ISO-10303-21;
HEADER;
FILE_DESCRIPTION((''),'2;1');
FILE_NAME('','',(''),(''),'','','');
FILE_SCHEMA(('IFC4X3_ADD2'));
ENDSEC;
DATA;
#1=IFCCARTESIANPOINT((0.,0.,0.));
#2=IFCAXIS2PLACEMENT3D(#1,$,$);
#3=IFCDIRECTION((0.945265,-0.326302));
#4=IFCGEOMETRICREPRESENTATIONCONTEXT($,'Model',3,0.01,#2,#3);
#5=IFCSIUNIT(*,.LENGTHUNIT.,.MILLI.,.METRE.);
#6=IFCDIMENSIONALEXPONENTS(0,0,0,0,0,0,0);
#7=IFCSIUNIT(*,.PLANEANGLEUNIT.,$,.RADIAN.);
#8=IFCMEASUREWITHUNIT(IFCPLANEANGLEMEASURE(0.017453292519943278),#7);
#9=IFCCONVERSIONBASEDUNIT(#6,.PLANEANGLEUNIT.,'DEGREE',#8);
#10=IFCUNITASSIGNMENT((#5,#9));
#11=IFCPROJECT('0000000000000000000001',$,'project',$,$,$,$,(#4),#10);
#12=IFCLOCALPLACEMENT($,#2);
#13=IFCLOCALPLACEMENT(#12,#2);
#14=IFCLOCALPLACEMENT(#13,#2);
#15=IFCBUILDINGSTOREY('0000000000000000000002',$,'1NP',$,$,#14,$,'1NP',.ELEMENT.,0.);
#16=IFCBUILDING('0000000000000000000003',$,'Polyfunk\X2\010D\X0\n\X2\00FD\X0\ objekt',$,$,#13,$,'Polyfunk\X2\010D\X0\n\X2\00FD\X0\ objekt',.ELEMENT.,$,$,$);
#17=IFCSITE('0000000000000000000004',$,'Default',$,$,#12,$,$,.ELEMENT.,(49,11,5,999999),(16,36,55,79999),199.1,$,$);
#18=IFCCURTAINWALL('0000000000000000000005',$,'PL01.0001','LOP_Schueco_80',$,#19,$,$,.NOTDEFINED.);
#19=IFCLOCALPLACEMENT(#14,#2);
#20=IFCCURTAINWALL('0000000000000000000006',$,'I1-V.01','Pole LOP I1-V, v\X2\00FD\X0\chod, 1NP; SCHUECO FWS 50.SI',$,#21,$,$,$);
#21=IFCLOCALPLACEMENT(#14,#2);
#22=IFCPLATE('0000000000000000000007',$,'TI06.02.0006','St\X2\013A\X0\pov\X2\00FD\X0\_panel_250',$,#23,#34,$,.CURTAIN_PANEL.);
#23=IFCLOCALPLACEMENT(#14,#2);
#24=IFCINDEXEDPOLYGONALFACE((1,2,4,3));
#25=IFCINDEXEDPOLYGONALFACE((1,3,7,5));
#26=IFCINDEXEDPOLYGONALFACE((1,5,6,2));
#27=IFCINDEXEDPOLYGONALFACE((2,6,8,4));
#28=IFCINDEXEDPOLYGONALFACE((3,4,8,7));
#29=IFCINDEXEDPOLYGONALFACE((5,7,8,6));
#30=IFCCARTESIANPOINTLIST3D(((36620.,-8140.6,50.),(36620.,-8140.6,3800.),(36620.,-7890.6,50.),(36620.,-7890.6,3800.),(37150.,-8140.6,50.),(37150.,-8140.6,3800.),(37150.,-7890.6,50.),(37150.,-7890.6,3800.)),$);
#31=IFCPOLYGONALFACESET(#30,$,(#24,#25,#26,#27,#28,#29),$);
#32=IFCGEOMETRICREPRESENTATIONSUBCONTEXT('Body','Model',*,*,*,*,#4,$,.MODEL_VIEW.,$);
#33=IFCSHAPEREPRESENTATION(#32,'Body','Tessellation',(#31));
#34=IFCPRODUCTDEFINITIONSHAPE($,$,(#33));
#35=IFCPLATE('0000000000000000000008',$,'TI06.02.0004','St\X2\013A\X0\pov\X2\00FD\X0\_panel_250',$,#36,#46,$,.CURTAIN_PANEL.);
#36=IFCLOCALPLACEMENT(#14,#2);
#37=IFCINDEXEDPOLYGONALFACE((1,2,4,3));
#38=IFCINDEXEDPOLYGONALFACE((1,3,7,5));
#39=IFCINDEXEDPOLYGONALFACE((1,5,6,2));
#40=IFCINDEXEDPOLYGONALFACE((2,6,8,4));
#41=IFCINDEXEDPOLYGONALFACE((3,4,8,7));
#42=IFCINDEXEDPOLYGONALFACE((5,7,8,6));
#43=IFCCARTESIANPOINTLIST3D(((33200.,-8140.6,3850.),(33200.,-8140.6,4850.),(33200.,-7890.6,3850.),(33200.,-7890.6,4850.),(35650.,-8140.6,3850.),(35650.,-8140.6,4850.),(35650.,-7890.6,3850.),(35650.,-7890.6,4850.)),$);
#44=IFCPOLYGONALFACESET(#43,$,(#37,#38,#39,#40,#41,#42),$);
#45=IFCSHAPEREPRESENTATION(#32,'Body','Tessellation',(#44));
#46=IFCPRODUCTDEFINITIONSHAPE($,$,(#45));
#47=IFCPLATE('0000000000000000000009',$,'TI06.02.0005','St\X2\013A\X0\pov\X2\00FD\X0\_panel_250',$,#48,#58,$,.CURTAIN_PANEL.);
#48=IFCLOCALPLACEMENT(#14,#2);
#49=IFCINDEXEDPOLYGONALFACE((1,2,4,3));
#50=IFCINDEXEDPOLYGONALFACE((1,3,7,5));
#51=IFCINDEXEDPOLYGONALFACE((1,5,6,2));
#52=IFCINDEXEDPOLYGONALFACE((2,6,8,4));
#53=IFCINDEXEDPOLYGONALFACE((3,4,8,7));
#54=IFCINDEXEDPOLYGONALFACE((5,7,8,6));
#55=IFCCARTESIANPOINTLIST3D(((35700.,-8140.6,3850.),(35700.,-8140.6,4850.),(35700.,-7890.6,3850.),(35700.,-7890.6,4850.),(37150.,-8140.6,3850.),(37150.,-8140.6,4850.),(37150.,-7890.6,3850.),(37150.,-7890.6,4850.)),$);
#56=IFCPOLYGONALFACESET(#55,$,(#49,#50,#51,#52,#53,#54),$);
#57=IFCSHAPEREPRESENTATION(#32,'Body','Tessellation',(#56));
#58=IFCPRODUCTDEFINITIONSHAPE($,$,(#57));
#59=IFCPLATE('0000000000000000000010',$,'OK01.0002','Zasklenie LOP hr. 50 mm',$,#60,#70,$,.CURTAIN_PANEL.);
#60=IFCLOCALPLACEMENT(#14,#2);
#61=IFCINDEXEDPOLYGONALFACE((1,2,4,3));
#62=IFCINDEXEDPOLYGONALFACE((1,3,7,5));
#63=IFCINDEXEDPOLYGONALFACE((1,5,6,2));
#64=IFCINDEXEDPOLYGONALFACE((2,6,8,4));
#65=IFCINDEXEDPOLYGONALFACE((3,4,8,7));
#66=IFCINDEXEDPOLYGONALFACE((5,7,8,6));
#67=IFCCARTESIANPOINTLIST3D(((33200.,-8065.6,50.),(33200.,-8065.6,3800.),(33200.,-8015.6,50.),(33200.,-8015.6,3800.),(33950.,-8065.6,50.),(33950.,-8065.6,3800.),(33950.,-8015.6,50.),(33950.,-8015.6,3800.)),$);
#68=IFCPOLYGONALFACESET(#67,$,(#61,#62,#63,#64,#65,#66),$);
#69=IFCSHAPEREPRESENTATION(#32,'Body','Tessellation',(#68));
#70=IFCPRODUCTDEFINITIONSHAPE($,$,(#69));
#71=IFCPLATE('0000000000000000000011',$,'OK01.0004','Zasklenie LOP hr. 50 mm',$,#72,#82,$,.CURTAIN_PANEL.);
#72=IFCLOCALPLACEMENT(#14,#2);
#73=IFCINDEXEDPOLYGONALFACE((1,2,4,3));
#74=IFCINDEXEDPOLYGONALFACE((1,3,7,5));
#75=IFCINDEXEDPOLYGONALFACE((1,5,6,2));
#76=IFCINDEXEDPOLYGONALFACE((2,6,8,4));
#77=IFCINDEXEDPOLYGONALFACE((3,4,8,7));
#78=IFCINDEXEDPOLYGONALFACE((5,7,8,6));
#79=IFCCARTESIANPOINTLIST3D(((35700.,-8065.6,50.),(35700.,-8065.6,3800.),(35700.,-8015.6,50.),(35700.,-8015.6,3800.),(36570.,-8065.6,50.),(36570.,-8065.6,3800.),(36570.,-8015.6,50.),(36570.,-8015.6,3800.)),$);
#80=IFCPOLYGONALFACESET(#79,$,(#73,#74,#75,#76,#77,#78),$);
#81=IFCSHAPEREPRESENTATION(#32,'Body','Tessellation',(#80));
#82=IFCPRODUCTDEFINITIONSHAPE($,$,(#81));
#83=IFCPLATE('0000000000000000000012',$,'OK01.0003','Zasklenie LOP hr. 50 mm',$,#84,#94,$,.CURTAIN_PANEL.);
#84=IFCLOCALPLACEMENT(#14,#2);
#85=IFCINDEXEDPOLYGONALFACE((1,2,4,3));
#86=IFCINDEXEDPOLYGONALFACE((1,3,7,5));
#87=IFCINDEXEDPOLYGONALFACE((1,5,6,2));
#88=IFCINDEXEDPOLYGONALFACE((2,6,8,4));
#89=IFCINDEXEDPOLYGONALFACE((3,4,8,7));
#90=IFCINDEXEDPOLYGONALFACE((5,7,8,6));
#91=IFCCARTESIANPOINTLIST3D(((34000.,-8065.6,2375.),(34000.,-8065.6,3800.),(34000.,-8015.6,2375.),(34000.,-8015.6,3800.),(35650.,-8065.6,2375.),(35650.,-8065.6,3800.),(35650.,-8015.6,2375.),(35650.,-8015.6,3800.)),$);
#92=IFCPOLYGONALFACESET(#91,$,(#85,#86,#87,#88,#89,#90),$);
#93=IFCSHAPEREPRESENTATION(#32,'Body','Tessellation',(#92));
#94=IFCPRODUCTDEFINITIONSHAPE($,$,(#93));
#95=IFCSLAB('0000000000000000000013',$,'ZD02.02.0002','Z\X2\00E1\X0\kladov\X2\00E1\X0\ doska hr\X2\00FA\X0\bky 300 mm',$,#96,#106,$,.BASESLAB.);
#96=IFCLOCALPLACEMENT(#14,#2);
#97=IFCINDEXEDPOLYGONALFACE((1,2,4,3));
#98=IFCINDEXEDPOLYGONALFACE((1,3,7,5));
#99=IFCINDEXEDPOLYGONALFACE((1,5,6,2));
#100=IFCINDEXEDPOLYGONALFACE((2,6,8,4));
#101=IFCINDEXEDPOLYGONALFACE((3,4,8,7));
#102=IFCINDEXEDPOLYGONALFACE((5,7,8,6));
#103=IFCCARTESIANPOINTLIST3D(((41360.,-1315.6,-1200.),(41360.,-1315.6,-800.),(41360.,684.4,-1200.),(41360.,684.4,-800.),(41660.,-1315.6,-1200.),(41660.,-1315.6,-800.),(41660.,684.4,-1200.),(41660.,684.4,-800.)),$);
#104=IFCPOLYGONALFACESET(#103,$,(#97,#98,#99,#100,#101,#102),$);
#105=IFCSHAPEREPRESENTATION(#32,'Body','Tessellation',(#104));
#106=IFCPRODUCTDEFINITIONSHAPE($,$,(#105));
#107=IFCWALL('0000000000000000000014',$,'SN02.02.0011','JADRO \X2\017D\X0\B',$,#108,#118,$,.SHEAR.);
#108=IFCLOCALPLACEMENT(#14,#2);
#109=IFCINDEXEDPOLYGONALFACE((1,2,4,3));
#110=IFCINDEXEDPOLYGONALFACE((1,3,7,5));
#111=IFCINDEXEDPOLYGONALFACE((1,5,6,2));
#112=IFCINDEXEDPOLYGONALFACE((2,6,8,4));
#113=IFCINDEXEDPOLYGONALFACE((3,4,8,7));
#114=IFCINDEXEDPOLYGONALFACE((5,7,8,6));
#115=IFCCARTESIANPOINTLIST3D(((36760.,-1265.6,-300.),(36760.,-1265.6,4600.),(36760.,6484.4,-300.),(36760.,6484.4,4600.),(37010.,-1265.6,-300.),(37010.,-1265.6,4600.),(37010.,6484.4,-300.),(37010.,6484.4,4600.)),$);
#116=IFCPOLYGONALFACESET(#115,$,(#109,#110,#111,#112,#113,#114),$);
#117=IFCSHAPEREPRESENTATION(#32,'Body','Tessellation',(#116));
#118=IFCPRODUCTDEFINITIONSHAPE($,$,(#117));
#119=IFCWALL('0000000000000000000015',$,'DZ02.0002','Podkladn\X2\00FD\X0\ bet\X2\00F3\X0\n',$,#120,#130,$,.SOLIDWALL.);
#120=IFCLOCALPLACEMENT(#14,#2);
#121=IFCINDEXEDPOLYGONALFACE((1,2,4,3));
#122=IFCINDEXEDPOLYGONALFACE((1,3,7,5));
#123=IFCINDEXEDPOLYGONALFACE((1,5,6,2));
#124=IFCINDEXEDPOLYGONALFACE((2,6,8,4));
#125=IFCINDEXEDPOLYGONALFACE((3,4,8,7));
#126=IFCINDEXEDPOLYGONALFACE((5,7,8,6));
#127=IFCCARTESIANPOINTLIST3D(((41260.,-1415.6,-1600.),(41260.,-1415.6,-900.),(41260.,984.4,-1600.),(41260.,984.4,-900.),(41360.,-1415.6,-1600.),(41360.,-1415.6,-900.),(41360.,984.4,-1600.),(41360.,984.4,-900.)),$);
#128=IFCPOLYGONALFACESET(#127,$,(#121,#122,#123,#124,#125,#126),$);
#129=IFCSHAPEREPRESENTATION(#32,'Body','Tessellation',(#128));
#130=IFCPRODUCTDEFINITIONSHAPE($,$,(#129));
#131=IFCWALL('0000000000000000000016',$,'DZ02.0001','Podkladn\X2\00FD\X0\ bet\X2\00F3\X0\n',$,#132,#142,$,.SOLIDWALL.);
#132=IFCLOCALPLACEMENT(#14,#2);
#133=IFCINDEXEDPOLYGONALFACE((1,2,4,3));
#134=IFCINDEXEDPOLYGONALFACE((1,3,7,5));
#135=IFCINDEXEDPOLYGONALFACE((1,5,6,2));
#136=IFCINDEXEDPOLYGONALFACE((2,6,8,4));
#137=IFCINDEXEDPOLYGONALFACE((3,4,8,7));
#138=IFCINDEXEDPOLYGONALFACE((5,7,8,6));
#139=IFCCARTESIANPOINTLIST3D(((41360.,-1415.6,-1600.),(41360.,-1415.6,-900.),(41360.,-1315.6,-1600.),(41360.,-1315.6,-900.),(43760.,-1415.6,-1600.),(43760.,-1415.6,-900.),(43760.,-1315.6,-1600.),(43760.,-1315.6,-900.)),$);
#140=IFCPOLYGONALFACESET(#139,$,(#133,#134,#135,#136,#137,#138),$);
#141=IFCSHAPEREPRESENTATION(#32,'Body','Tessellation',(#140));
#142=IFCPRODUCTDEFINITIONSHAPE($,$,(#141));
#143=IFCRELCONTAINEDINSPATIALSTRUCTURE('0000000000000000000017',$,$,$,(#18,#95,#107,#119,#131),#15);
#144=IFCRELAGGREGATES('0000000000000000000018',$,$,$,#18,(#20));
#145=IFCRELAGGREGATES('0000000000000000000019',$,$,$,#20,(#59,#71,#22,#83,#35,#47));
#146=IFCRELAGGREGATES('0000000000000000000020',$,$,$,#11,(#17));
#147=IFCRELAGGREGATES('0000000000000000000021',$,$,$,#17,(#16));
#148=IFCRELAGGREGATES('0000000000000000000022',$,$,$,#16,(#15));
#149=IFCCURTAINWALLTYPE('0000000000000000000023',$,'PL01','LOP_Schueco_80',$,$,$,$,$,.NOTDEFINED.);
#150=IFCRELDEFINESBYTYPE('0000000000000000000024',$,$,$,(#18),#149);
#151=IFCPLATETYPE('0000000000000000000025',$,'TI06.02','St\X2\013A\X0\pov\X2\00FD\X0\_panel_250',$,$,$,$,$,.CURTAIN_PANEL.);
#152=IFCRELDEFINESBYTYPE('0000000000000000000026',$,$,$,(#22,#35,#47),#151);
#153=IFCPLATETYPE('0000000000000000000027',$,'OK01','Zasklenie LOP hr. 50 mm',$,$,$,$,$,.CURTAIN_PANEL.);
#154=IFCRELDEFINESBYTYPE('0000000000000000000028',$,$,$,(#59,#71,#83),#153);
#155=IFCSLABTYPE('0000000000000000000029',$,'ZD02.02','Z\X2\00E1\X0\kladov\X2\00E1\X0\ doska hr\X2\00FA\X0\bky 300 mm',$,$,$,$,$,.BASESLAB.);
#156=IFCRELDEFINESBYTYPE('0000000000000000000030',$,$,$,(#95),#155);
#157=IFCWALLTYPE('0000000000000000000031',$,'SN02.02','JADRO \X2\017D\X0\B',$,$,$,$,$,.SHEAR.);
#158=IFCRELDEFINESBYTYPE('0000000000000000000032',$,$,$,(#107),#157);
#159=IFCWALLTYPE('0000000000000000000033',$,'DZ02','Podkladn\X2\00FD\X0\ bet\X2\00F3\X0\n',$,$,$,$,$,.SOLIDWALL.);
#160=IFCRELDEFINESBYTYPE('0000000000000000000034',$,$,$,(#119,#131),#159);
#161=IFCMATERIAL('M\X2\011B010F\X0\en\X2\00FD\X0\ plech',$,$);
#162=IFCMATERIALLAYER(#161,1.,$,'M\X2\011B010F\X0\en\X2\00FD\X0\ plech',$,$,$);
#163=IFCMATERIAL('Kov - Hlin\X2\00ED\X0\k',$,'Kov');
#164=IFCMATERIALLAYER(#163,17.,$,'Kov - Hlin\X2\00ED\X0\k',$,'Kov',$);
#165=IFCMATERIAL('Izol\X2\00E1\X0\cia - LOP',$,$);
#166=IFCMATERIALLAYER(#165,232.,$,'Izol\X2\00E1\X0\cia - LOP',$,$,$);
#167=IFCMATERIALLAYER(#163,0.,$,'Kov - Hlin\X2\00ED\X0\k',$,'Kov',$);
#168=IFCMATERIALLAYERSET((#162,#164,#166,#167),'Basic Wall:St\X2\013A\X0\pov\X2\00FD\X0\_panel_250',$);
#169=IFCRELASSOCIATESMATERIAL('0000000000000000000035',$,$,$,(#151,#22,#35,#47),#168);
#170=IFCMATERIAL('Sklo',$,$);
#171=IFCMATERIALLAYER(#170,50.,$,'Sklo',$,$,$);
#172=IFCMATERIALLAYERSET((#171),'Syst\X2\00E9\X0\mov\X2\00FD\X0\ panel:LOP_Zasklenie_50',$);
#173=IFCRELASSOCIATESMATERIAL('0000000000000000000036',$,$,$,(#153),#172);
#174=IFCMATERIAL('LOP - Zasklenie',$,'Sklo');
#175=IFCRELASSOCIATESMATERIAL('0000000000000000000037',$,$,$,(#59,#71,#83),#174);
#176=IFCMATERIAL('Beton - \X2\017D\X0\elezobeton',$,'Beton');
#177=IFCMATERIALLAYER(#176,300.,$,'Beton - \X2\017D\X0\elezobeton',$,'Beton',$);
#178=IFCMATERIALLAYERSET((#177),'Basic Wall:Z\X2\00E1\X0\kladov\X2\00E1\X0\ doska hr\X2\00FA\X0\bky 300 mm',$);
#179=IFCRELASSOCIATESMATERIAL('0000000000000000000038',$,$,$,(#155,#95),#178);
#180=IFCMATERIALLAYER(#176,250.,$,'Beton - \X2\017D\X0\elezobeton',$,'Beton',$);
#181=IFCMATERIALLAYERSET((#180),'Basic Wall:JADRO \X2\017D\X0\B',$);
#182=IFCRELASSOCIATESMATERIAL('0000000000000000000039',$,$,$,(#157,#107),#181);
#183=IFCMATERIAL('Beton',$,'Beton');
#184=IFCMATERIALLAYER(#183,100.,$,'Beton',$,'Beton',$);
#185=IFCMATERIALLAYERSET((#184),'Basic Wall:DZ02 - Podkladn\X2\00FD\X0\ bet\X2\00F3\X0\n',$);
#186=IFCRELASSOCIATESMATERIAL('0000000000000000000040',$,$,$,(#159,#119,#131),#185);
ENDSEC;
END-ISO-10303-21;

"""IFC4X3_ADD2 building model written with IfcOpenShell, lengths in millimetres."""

from ifc_helpers import new_model, entity, si_unit, converted_unit, direction, frame, frame_2d, origin, place, context, subcontext, project, spatial, polyline, rectangle, extrude, clip, bounded_halfspace, source, transform, mapped, material, layer, layer_set, layer_usage, type_object, type_shapes, element, aggregate, save


model = new_model("IFC4X3_ADD2")

# Units and contexts
model_context = context("Model", 3, precision=0.01, world=origin(), true_north=direction((0.945265, -0.326302)))
body_context = subcontext(model_context, "Body", "Model", "MODEL_VIEW")
ifc_project = project(units=[si_unit("LENGTHUNIT", "METRE", prefix="MILLI"), converted_unit("PLANEANGLEUNIT", "DEGREE", entity("IfcPlaneAngleMeasure", 0.017453292519943278), si_unit("PLANEANGLEUNIT", "RADIAN"), dimensions=[0, 0, 0, 0, 0, 0, 0])], contexts=[model_context])

# Site, building, storey
site_placement = place(None, origin())
site = spatial("IfcSite", under=ifc_project, at=site_placement, Name="Default", CompositionType="ELEMENT", RefLatitude=(49, 11, 5, 999999), RefLongitude=(16, 36, 55, 79999), RefElevation=199.1)
building_placement = place(site_placement, origin())
building = spatial("IfcBuilding", under=site, at=building_placement, Name="Polyfunkčný objekt", LongName="Polyfunkčný objekt", CompositionType="ELEMENT")
storey_placement = place(building_placement, origin())
storey = spatial("IfcBuildingStorey", under=building, at=storey_placement, Name="1NP", LongName="1NP", CompositionType="ELEMENT", Elevation=0.0)

# Curtain walls, plates
curtain_wall_type = type_object("IfcCurtainWallType", Name="PL01", Description="LOP_Schueco_80", PredefinedType="NOTDEFINED")
curtain_wall_1_placement = place(storey_placement, origin())
curtain_wall_1 = element("IfcCurtainWall", 1, at=curtain_wall_1_placement, inside=storey, type_object=curtain_wall_type, Name="PL01.0001", Description="LOP_Schueco_80", PredefinedType="NOTDEFINED")
curtain_wall_2 = element("IfcCurtainWall", 2, Name="I1-V.01", Description="Pole LOP I1-V, východ, 1NP; SCHUECO FWS 50.SI")
aggregate(curtain_wall_1, [curtain_wall_2])
ifc_material_1 = material(Name="Měďený plech")
ifc_layer_1 = layer(ifc_material_1, 1.0, Name="Měďený plech")
ifc_material_2 = material(Name="Kov - Hliník", Category="Kov")
ifc_layer_2 = layer(ifc_material_2, 17.0, Name="Kov - Hliník", Category="Kov")
ifc_material_3 = material(Name="Izolácia - LOP")
ifc_layer_3 = layer(ifc_material_3, 232.0, Name="Izolácia - LOP")
ifc_layer_4 = layer(ifc_material_2, 0.0, Name="Kov - Hliník", Category="Kov")
ifc_layer_set_1 = layer_set([ifc_layer_1, ifc_layer_2, ifc_layer_3, ifc_layer_4], Name="Basic Wall:Stĺpový_panel_250")
ifc_layer_usage_1 = layer_usage(ifc_layer_set_1, "AXIS2", "POSITIVE", -125.0)
plate_type_1 = type_object("IfcPlateType", Name="TI06.02", Description="Stĺpový_panel_250", PredefinedType="CURTAIN_PANEL", material=ifc_layer_set_1)
plate_1_placement = place(storey_placement, frame((36620.0, -8015.6, 50.0)))
plate_1 = element("IfcPlate", 3, at=plate_1_placement, type_object=plate_type_1, material=ifc_layer_usage_1, Name="TI06.02.0006", Description="Stĺpový_panel_250", PredefinedType="CURTAIN_PANEL", context=body_context, shape_type="SweptSolid", body=[
    extrude(rectangle(XDim=250.0, YDim=530.0, at=frame_2d((0.0, 0.0), x_axis=(1.0, 0.0))), frame((265.0, 0.0, 0.0), z_axis=(0.0, 0.0, 1.0), x_axis=(0.0, 1.0, 0.0)), (0.0, 0.0, 1.0), 3750.0),
])
ifc_layer_usage_2 = layer_usage(ifc_layer_set_1, "AXIS2", "POSITIVE", -125.0)
plate_2_placement = place(storey_placement, frame((33200.0, -8015.6, 3850.0)))
plate_2 = element("IfcPlate", 4, at=plate_2_placement, type_object=plate_type_1, material=ifc_layer_usage_2, Name="TI06.02.0004", Description="Stĺpový_panel_250", PredefinedType="CURTAIN_PANEL", context=body_context, shape_type="SweptSolid", body=[
    extrude(rectangle(XDim=250.0, YDim=2450.0, at=frame_2d((0.0, 0.0), x_axis=(1.0, 0.0))), frame((1225.0, 0.0, 0.0), z_axis=(0.0, 0.0, 1.0), x_axis=(0.0, 1.0, 0.0)), (0.0, 0.0, 1.0), 1000.0),
])
ifc_layer_usage_3 = layer_usage(ifc_layer_set_1, "AXIS2", "POSITIVE", -125.0)
plate_3_placement = place(storey_placement, frame((35700.0, -8015.6, 3850.0)))
plate_3 = element("IfcPlate", 5, at=plate_3_placement, type_object=plate_type_1, material=ifc_layer_usage_3, Name="TI06.02.0005", Description="Stĺpový_panel_250", PredefinedType="CURTAIN_PANEL", context=body_context, shape_type="SweptSolid", body=[
    extrude(rectangle(XDim=250.0, YDim=1450.0, at=frame_2d((0.0, 0.0), x_axis=(1.0, 0.0))), frame((725.0, 0.0, 0.0), z_axis=(0.0, 0.0, 1.0), x_axis=(0.0, 1.0, 0.0)), (0.0, 0.0, 1.0), 1000.0),
])
ifc_material_4 = material(Name="LOP - Zasklenie", Category="Sklo")
ifc_material_5 = material(Name="Sklo")
ifc_layer_5 = layer(ifc_material_5, 50.0, Name="Sklo")
ifc_layer_set_2 = layer_set([ifc_layer_5], Name="Systémový panel:LOP_Zasklenie_50")
plate_type_2 = type_object("IfcPlateType", Name="OK01", Description="Zasklenie LOP hr. 50 mm", PredefinedType="CURTAIN_PANEL", material=ifc_layer_set_2)
shared_shape_1 = source(origin(), body_context, "Body", "SweptSolid", [
    extrude(rectangle(XDim=3750.0, YDim=750.0, at=frame_2d((-331.2, 0.0), x_axis=(1.0, 0.0))), frame((0.0, -50.0, 2206.2), z_axis=(0.0, 1.0, 0.0), x_axis=(0.0, 0.0, 1.0)), (0.0, 0.0, 1.0), 50.0),
])
plate_4_placement = place(curtain_wall_1_placement, frame((33575.0, -8015.6, 50.0)))
plate_4 = element("IfcPlate", 6, at=plate_4_placement, type_object=plate_type_2, material=ifc_material_4, Name="OK01.0002", Description="Zasklenie LOP hr. 50 mm", PredefinedType="CURTAIN_PANEL", context=body_context, shape_type="MappedRepresentation", body=[
    mapped(shared_shape_1, transform((0.0, 0.0, 0.0), scale=1.0)),
])
shared_shape_2 = source(origin(), body_context, "Body", "SweptSolid", [
    extrude(rectangle(XDim=3750.0, YDim=870.0, at=frame_2d((-331.2, 0.0), x_axis=(1.0, 0.0))), frame((0.0, -50.0, 2206.2), z_axis=(0.0, 1.0, 0.0), x_axis=(0.0, 0.0, 1.0)), (0.0, 0.0, 1.0), 50.0),
])
plate_5_placement = place(curtain_wall_1_placement, frame((36135.0, -8015.6, 50.0)))
plate_5 = element("IfcPlate", 7, at=plate_5_placement, type_object=plate_type_2, material=ifc_material_4, Name="OK01.0004", Description="Zasklenie LOP hr. 50 mm", PredefinedType="CURTAIN_PANEL", context=body_context, shape_type="MappedRepresentation", body=[
    mapped(shared_shape_2, transform((0.0, 0.0, 0.0), scale=1.0)),
])
shared_shape_3 = source(origin(), body_context, "Body", "SweptSolid", [
    extrude(rectangle(XDim=1425.0, YDim=1650.0, at=frame_2d((87.6, 0.0), x_axis=(1.0, 0.0))), frame((0.0, -50.0, 624.9), z_axis=(0.0, 1.0, 0.0), x_axis=(0.0, 0.0, 1.0)), (0.0, 0.0, 1.0), 50.0),
])
type_shapes(plate_type_2, [shared_shape_1, shared_shape_2, shared_shape_3])
plate_6_placement = place(curtain_wall_1_placement, frame((34825.0, -8015.6, 2375.0)))
plate_6 = element("IfcPlate", 8, at=plate_6_placement, type_object=plate_type_2, material=ifc_material_4, Name="OK01.0003", Description="Zasklenie LOP hr. 50 mm", PredefinedType="CURTAIN_PANEL", context=body_context, shape_type="MappedRepresentation", body=[
    mapped(shared_shape_3, transform((0.0, 0.0, 0.0), scale=1.0)),
])
aggregate(curtain_wall_2, [plate_4, plate_5, plate_1, plate_6, plate_2, plate_3])

# Slab
ifc_material_6 = material(Name="Beton - Železobeton", Category="Beton")
ifc_layer_6 = layer(ifc_material_6, 300.0, Name="Beton - Železobeton", Category="Beton")
ifc_layer_set_3 = layer_set([ifc_layer_6], Name="Basic Wall:Základová doska hrúbky 300 mm")
slab_type = type_object("IfcSlabType", Name="ZD02.02", Description="Základová doska hrúbky 300 mm", PredefinedType="BASESLAB", material=ifc_layer_set_3)
slab_placement = place(storey_placement, frame((41510.0, -1315.6, -1200.0), z_axis=(0.0, 0.0, 1.0), x_axis=(0.0, 1.0, 0.0)))
element("IfcSlab", 9, at=slab_placement, inside=storey, type_object=slab_type, material=ifc_layer_set_3, Name="ZD02.02.0002", Description="Základová doska hrúbky 300 mm", PredefinedType="BASESLAB", context=body_context, shape_type="SweptSolid", body=[
    extrude(rectangle(XDim=2000.0, YDim=300.0, at=frame_2d((1000.0, 0.0), x_axis=(-1.0, 0.0))), origin(), (0.0, 0.0, 1.0), 400.0),
])

# Walls
ifc_layer_7 = layer(ifc_material_6, 250.0, Name="Beton - Železobeton", Category="Beton")
ifc_layer_set_4 = layer_set([ifc_layer_7], Name="Basic Wall:JADRO ŽB")
wall_type_1 = type_object("IfcWallType", Name="SN02.02", Description="JADRO ŽB", PredefinedType="SHEAR", material=ifc_layer_set_4)
wall_1_placement = place(storey_placement, frame((36885.0, -1265.6, -300.0), z_axis=(0.0, 0.0, 1.0), x_axis=(0.0, 1.0, 0.0)))
element("IfcWall", 10, at=wall_1_placement, inside=storey, type_object=wall_type_1, material=ifc_layer_set_4, Name="SN02.02.0011", Description="JADRO ŽB", PredefinedType="SHEAR", context=body_context, shape_type="Clipping", body=[
    clip(clip(extrude(rectangle(XDim=7750.0, YDim=250.0, at=frame_2d((3875.0, 0.0), x_axis=(-1.0, 0.0))), origin(), (0.0, 0.0, 1.0), 4900.0), bounded_halfspace(frame((7750.0, 125.0, 4900.0), z_axis=(0.0, 0.0, -1.0), x_axis=(0.0, -1.0, 0.0)), True, frame((7750.0, 125.0, 4900.0)), polyline([(0.0, 0.0), (-7750.0, 0.0), (-7750.0, -250.0), (-7500.0, -250.0), (-5800.0, -250.0), (-5550.0, -250.0), (-3200.0, -250.0), (-2950.0, -250.0), (-250.0, -250.0), (0.0, -250.0), (0.0, 0.0)]))), bounded_halfspace(frame((7750.0, -125.0, 0.0)), True, frame((7750.0, -125.0, 0.0)), polyline([(0.0, 0.0), (0.0, 250.0), (-390.0, 250.0), (-7750.0, 250.0), (-7750.0, 0.0), (-7500.0, 0.0), (-5800.0, 0.0), (-5550.0, 0.0), (-3200.0, 0.0), (-2950.0, 0.0), (-250.0, 0.0), (0.0, 0.0)]))),
])
ifc_material_7 = material(Name="Beton", Category="Beton")
ifc_layer_8 = layer(ifc_material_7, 100.0, Name="Beton", Category="Beton")
ifc_layer_set_5 = layer_set([ifc_layer_8], Name="Basic Wall:DZ02 - Podkladný betón")
wall_type_2 = type_object("IfcWallType", Name="DZ02", Description="Podkladný betón", PredefinedType="SOLIDWALL", material=ifc_layer_set_5)
wall_2_placement = place(storey_placement, frame((41310.0, -1415.6, -1600.0), z_axis=(0.0, 0.0, 1.0), x_axis=(0.0, 1.0, 0.0)))
element("IfcWall", 11, at=wall_2_placement, inside=storey, type_object=wall_type_2, material=ifc_layer_set_5, Name="DZ02.0002", Description="Podkladný betón", PredefinedType="SOLIDWALL", context=body_context, shape_type="SweptSolid", body=[
    extrude(rectangle(XDim=2400.0, YDim=100.0, at=frame_2d((1200.0, 0.0), x_axis=(-1.0, 0.0))), origin(), (0.0, 0.0, 1.0), 700.0),
])
wall_3_placement = place(storey_placement, frame((43760.0, -1365.6, -1600.0), z_axis=(0.0, 0.0, 1.0), x_axis=(-1.0, 0.0, 0.0)))
element("IfcWall", 12, at=wall_3_placement, inside=storey, type_object=wall_type_2, material=ifc_layer_set_5, Name="DZ02.0001", Description="Podkladný betón", PredefinedType="SOLIDWALL", context=body_context, shape_type="SweptSolid", body=[
    extrude(rectangle(XDim=2400.0, YDim=100.0, at=frame_2d((1200.0, 0.0), x_axis=(-1.0, 0.0))), origin(), (0.0, 0.0, 1.0), 700.0),
])

save(model, "model.ifc")
